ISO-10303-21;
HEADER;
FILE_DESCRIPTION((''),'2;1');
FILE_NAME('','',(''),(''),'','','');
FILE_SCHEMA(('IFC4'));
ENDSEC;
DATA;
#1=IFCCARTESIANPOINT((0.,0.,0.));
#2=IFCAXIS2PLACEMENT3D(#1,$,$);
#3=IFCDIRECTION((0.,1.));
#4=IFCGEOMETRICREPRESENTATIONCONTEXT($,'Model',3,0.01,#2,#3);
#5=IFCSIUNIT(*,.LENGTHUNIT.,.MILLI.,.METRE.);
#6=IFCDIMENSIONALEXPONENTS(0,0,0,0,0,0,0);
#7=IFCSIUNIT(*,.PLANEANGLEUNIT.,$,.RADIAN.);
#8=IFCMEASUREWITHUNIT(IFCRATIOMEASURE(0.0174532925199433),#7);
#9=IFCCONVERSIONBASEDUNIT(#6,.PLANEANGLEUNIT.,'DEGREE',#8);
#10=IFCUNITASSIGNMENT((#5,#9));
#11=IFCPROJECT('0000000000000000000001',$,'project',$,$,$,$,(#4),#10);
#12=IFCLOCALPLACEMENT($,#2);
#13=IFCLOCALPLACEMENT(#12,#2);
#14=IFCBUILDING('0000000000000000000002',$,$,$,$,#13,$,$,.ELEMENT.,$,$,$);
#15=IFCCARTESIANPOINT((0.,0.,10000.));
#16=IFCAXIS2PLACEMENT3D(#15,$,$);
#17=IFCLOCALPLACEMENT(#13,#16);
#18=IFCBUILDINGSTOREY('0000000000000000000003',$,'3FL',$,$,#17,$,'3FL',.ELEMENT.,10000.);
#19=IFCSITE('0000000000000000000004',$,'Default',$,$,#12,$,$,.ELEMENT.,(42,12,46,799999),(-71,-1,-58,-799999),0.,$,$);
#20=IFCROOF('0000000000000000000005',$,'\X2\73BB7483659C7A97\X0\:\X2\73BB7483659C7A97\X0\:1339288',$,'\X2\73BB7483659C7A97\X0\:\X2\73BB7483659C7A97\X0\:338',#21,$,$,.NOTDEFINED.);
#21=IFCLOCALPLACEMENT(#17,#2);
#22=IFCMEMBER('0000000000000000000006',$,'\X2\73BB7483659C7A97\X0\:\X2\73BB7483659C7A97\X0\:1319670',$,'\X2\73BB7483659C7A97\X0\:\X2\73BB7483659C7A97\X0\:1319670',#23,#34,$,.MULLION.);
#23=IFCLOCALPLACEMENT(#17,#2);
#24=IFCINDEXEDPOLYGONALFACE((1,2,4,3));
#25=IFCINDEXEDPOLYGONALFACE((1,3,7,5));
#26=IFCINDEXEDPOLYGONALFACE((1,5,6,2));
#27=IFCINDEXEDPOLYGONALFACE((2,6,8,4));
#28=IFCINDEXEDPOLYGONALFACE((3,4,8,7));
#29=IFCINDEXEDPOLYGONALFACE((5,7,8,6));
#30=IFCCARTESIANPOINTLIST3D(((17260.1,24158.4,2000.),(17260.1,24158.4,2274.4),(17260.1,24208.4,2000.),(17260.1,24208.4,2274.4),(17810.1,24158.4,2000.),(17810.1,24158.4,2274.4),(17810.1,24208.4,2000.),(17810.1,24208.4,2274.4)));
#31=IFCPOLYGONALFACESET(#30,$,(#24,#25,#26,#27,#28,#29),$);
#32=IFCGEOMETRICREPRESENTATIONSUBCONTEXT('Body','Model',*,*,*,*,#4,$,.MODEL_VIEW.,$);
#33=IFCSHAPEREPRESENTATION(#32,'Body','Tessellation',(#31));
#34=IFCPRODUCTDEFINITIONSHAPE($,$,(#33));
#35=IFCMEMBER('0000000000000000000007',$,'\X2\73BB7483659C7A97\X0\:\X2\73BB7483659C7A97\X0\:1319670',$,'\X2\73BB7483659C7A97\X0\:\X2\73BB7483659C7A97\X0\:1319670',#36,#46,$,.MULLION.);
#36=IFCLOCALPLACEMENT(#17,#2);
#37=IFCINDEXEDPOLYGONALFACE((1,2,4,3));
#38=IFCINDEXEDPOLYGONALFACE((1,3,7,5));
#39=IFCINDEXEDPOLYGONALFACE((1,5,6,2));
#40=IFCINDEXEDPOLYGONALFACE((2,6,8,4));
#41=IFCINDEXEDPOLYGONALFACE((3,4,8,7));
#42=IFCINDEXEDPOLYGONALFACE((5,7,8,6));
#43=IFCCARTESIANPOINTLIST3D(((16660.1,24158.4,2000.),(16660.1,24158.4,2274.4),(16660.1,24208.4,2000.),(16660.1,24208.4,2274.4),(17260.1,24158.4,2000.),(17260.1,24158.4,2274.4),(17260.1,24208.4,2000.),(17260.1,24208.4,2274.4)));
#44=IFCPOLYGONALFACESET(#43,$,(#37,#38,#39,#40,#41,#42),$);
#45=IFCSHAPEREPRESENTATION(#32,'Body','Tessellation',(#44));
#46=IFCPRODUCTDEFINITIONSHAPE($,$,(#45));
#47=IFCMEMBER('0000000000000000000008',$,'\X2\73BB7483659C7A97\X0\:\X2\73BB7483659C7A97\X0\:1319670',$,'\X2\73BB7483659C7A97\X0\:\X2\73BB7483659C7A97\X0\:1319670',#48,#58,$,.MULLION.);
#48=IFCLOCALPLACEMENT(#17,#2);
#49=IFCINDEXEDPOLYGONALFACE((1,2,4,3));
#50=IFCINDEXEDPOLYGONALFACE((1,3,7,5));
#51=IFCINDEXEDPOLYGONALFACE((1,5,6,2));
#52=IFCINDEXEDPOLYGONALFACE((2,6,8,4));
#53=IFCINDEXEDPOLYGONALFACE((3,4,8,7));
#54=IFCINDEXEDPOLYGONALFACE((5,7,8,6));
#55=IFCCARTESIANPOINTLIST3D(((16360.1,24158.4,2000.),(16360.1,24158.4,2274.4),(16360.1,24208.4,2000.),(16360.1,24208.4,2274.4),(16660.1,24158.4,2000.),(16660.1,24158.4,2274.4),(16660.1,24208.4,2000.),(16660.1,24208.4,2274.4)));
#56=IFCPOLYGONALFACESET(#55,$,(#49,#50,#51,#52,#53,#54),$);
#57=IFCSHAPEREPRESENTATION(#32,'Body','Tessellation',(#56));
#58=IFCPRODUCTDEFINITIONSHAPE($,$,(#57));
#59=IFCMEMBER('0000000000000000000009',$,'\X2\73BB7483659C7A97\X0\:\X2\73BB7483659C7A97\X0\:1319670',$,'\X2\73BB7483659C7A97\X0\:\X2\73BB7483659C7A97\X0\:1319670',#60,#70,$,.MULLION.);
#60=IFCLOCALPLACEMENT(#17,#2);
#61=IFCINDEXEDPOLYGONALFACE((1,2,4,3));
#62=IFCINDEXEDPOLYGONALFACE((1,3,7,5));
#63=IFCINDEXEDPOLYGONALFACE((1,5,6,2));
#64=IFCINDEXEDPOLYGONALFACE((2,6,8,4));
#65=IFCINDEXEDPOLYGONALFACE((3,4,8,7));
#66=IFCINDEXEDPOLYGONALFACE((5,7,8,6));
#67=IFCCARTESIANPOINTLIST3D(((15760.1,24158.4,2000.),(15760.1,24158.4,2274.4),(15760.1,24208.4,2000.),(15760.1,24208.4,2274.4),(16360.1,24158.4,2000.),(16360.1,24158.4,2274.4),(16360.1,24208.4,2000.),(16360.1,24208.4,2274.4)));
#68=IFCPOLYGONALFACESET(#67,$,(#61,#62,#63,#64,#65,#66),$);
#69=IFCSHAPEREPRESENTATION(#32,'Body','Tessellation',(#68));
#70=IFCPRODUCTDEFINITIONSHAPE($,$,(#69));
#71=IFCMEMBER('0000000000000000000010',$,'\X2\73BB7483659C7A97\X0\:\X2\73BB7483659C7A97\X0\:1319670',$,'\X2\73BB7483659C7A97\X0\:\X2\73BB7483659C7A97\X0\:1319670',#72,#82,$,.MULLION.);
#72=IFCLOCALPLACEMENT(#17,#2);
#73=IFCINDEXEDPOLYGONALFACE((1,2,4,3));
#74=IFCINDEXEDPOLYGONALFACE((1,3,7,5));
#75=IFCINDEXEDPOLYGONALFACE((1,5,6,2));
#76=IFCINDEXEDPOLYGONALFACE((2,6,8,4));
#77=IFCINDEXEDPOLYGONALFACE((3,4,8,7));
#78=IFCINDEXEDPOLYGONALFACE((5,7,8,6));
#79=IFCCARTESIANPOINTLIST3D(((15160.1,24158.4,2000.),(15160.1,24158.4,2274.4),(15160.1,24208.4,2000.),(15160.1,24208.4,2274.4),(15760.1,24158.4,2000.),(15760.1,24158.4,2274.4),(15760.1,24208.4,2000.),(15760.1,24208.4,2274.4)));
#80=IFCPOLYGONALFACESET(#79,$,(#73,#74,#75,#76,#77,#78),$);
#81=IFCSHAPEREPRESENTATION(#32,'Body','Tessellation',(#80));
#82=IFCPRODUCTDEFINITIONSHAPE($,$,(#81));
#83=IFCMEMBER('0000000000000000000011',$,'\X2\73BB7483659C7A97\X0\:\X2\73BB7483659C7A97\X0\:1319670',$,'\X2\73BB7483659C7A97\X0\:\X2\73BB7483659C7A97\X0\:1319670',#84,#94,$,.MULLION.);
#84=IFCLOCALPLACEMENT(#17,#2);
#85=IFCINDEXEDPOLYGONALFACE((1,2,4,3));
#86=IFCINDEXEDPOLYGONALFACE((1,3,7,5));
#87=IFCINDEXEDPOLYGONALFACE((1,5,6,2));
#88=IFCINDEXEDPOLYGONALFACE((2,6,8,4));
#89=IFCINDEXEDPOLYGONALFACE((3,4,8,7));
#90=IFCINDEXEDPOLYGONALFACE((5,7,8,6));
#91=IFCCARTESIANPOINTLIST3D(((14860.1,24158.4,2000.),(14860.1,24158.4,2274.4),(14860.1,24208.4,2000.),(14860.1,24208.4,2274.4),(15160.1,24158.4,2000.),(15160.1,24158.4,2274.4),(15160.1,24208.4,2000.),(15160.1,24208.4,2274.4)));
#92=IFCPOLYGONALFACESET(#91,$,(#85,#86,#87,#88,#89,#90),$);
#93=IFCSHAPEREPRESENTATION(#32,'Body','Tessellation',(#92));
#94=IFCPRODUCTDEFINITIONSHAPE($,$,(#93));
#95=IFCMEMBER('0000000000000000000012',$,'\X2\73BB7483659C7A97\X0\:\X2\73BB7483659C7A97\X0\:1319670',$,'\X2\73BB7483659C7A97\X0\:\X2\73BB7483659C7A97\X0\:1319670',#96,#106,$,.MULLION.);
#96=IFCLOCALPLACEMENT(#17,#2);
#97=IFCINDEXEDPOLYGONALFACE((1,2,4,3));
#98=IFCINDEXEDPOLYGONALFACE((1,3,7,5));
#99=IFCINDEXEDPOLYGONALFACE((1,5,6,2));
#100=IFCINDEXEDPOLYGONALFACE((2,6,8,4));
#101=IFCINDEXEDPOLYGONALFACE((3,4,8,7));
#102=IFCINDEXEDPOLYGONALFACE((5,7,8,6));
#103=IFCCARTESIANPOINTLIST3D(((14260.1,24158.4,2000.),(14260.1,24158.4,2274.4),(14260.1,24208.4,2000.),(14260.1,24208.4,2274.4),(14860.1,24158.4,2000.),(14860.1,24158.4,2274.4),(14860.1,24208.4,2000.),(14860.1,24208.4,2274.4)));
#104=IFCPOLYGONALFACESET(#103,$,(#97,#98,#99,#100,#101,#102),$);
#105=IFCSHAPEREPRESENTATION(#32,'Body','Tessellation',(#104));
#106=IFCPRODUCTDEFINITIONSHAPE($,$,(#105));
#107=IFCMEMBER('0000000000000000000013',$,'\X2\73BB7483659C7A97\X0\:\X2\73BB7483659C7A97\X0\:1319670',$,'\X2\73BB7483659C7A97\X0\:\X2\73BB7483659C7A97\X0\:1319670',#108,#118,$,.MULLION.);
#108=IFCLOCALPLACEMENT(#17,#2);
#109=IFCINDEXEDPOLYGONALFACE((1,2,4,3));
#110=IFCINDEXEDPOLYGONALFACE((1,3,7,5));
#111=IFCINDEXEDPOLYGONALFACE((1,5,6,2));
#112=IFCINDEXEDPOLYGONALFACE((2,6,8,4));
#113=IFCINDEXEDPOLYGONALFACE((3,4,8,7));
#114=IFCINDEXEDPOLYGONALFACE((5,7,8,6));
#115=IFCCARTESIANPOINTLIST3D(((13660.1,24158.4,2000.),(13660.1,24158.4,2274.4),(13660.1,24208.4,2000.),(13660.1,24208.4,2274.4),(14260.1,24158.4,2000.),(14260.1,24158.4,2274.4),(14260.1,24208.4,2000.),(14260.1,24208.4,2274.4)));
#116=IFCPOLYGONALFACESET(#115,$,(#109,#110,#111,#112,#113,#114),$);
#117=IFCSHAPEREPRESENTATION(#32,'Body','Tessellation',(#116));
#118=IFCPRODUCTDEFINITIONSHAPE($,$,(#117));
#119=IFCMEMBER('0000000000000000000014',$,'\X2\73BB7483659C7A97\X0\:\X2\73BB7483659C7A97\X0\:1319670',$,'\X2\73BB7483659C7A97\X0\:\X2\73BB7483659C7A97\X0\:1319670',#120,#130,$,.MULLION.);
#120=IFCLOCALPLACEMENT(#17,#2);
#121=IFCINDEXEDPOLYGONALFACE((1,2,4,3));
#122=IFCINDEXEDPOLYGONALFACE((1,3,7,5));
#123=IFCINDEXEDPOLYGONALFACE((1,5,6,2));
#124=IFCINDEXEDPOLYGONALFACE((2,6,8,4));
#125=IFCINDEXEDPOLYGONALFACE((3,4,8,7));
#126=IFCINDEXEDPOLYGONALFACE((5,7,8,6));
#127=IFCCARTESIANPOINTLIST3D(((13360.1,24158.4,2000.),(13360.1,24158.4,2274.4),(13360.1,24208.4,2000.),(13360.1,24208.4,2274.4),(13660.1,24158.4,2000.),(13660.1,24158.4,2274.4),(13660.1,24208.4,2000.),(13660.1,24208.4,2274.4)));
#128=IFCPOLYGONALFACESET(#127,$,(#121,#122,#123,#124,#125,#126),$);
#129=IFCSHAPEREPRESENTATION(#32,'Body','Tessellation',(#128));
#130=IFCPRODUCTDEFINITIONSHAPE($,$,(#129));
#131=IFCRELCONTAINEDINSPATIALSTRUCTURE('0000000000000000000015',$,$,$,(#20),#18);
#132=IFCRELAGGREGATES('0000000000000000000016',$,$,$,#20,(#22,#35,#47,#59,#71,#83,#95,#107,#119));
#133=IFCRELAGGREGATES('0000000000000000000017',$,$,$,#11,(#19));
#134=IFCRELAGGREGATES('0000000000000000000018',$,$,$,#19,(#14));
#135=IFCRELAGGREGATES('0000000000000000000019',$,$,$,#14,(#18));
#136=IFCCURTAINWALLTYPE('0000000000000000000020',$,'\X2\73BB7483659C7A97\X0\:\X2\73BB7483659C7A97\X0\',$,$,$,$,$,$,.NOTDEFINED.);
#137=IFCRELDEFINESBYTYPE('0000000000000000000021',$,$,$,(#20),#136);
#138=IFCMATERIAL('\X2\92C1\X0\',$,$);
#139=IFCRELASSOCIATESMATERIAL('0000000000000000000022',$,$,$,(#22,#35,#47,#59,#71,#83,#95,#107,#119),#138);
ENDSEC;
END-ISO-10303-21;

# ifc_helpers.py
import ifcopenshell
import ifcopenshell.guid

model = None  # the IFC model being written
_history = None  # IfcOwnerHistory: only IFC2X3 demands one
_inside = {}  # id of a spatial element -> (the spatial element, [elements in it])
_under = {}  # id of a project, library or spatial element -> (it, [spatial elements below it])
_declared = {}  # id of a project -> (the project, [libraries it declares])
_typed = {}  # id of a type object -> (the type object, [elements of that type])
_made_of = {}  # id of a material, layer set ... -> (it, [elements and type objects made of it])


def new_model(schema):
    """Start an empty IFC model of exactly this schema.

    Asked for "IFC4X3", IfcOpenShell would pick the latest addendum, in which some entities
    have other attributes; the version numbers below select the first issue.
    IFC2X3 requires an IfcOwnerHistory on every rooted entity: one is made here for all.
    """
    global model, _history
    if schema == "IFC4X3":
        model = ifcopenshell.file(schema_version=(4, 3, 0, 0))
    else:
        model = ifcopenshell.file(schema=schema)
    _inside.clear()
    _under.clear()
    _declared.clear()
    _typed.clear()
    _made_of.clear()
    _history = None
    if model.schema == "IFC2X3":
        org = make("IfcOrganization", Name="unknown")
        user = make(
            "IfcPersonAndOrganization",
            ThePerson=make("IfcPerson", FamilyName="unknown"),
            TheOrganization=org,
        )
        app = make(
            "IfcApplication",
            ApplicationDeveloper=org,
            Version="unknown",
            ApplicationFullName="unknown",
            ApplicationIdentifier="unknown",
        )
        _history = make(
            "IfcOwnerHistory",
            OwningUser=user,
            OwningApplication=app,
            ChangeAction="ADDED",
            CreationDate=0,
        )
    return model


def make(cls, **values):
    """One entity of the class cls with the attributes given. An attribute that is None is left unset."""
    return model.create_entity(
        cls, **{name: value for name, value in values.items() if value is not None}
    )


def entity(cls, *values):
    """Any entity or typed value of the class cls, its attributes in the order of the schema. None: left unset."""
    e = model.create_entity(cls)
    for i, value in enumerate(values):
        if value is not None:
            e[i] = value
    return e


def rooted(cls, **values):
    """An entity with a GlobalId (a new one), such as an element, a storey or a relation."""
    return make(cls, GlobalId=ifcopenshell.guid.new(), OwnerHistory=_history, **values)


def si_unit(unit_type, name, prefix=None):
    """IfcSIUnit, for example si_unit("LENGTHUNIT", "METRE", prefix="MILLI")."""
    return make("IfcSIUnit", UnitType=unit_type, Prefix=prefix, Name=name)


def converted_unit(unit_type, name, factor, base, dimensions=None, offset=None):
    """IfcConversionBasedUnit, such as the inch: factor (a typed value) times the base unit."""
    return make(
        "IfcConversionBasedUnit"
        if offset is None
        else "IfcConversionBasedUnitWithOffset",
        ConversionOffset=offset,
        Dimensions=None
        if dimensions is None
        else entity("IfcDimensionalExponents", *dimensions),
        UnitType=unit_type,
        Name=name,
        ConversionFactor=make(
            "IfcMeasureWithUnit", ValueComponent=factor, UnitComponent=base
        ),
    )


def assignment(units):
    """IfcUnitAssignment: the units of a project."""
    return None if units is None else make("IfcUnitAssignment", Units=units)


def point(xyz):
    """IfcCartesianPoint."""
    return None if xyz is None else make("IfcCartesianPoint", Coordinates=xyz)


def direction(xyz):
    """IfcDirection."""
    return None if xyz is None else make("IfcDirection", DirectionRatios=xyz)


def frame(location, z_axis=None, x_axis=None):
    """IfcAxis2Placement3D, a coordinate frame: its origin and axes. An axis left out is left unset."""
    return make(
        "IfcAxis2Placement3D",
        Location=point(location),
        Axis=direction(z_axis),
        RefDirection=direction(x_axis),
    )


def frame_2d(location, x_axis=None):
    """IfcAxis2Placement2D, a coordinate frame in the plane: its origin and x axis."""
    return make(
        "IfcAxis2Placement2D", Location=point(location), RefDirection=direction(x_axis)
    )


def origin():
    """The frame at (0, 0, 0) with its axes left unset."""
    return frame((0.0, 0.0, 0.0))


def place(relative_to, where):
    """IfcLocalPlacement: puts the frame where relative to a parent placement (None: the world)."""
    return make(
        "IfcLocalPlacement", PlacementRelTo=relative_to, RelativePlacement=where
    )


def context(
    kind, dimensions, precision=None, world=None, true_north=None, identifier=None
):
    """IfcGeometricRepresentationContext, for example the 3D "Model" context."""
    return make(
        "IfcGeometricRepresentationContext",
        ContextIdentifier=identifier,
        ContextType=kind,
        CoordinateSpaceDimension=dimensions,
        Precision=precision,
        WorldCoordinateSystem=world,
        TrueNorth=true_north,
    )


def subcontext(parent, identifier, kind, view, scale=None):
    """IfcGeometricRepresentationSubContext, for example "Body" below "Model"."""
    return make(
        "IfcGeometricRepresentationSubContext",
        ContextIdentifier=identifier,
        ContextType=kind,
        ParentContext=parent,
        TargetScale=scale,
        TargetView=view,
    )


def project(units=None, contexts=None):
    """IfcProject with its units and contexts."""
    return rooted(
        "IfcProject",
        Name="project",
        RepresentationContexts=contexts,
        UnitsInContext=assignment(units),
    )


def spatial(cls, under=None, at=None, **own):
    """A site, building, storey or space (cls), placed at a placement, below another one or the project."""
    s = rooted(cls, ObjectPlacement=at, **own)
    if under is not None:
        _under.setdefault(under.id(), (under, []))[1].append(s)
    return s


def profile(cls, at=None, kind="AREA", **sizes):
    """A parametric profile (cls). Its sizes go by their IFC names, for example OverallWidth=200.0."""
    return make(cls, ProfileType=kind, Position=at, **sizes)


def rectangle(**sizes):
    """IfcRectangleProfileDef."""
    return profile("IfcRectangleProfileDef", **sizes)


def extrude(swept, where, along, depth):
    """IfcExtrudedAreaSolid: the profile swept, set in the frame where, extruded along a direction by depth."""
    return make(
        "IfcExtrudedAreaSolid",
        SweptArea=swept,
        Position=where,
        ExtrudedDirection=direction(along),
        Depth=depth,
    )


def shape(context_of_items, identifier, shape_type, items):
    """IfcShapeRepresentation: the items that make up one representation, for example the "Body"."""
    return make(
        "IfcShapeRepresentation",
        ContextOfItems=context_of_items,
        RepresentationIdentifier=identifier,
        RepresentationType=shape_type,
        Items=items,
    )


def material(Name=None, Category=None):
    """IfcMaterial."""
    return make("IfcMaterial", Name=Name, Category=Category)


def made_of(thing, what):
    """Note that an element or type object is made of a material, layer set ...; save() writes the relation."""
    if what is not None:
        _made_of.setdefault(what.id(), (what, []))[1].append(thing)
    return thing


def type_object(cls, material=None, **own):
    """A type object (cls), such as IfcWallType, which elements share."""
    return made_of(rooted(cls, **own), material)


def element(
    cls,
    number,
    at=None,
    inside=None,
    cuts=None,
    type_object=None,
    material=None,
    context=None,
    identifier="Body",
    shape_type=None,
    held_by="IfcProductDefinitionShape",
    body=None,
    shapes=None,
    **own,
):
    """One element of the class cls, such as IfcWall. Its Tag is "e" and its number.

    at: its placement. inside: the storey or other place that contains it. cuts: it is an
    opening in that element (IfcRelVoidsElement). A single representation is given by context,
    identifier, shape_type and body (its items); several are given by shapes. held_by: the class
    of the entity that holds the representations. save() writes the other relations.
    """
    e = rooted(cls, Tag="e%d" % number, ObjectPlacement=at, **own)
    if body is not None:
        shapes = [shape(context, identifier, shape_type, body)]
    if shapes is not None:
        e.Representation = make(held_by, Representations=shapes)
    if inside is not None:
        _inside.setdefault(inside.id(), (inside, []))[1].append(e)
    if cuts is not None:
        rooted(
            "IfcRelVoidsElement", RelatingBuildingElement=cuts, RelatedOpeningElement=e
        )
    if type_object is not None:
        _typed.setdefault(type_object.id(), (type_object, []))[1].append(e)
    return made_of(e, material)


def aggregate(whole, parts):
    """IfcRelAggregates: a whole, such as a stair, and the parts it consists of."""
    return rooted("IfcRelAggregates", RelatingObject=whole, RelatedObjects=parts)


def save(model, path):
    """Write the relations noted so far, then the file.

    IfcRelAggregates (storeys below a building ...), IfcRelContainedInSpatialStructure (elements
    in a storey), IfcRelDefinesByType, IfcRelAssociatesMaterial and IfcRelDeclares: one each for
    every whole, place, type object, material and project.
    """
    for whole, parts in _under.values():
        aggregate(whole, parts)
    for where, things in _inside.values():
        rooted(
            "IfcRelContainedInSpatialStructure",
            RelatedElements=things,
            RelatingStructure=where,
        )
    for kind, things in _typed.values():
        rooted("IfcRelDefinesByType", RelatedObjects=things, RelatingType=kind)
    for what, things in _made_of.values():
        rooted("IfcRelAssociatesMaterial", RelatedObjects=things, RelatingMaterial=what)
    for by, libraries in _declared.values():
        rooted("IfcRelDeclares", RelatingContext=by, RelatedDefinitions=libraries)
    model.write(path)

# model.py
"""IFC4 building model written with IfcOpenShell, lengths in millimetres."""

from ifc_helpers import new_model, entity, si_unit, converted_unit, direction, frame, frame_2d, origin, place, context, subcontext, project, spatial, rectangle, extrude, material, type_object, element, aggregate, save


model = new_model("IFC4")

# Units and contexts
model_context = context("Model", 3, precision=0.01, world=origin(), true_north=direction((0.0, 1.0)))
body_context = subcontext(model_context, "Body", "Model", "MODEL_VIEW")
ifc_project = project(units=[si_unit("LENGTHUNIT", "METRE", prefix="MILLI"), converted_unit("PLANEANGLEUNIT", "DEGREE", entity("IfcRatioMeasure", 0.0174532925199433), si_unit("PLANEANGLEUNIT", "RADIAN"), dimensions=[0, 0, 0, 0, 0, 0, 0])], contexts=[model_context])

# Site, building, storey
site_placement = place(None, origin())
site = spatial("IfcSite", under=ifc_project, at=site_placement, Name="Default", CompositionType="ELEMENT", RefLatitude=(42, 12, 46, 799999), RefLongitude=(-71, -1, -58, -799999), RefElevation=0.0)
building_placement = place(site_placement, origin())
building = spatial("IfcBuilding", under=site, at=building_placement, CompositionType="ELEMENT")
storey_placement = place(building_placement, frame((0.0, 0.0, 10000.0)))
storey = spatial("IfcBuildingStorey", under=building, at=storey_placement, Name="3FL", LongName="3FL", CompositionType="ELEMENT", Elevation=10000.0)

# Roof, members
curtain_wall_type = type_object("IfcCurtainWallType", Name="玻璃斜窗:玻璃斜窗", PredefinedType="NOTDEFINED")
ifc_material = material(Name="鋁")
roof_1_placement = place(storey_placement, frame((0.0, 0.0, -10000.0)))
roof_1 = element("IfcRoof", 1, at=roof_1_placement, inside=storey, type_object=curtain_wall_type, Name="玻璃斜窗:玻璃斜窗:1339288", ObjectType="玻璃斜窗:玻璃斜窗:338", PredefinedType="NOTDEFINED")
member_1_placement = place(roof_1_placement, frame((0.0, 0.0, 10000.0)))
member_1 = element("IfcMember", 2, at=member_1_placement, material=ifc_material, Name="玻璃斜窗:玻璃斜窗:1319670", ObjectType="玻璃斜窗:玻璃斜窗:1319670", PredefinedType="MULLION", context=body_context, shape_type="SweptSolid", body=[
    extrude(rectangle(XDim=274.5, YDim=50.0, at=frame_2d((0.0, 0.0), x_axis=(1.0, 0.0))), frame((17260.1, 24183.4, 2137.2), z_axis=(1.0, 0.0, 0.0), x_axis=(0.0, 0.0, -1.0)), (0.0, 0.0, 1.0), 550.0),
])
member_2_placement = place(roof_1_placement, frame((0.0, 0.0, 10000.0)))
member_2 = element("IfcMember", 3, at=member_2_placement, material=ifc_material, Name="玻璃斜窗:玻璃斜窗:1319670", ObjectType="玻璃斜窗:玻璃斜窗:1319670", PredefinedType="MULLION", context=body_context, shape_type="SweptSolid", body=[
    extrude(rectangle(XDim=274.5, YDim=50.0, at=frame_2d((0.0, 0.0), x_axis=(1.0, 0.0))), frame((16660.1, 24183.4, 2137.2), z_axis=(1.0, 0.0, 0.0), x_axis=(0.0, 0.0, -1.0)), (0.0, 0.0, 1.0), 600.0),
])
member_3_placement = place(roof_1_placement, frame((0.0, 0.0, 10000.0)))
member_3 = element("IfcMember", 4, at=member_3_placement, material=ifc_material, Name="玻璃斜窗:玻璃斜窗:1319670", ObjectType="玻璃斜窗:玻璃斜窗:1319670", PredefinedType="MULLION", context=body_context, shape_type="SweptSolid", body=[
    extrude(rectangle(XDim=274.5, YDim=50.0, at=frame_2d((0.0, 0.0), x_axis=(1.0, 0.0))), frame((16360.1, 24183.4, 2137.2), z_axis=(1.0, 0.0, 0.0), x_axis=(0.0, 0.0, -1.0)), (0.0, 0.0, 1.0), 300.0),
])
member_4_placement = place(roof_1_placement, frame((0.0, 0.0, 10000.0)))
member_4 = element("IfcMember", 5, at=member_4_placement, material=ifc_material, Name="玻璃斜窗:玻璃斜窗:1319670", ObjectType="玻璃斜窗:玻璃斜窗:1319670", PredefinedType="MULLION", context=body_context, shape_type="SweptSolid", body=[
    extrude(rectangle(XDim=274.5, YDim=50.0, at=frame_2d((0.0, 0.0), x_axis=(1.0, 0.0))), frame((15760.1, 24183.4, 2137.2), z_axis=(1.0, 0.0, 0.0), x_axis=(0.0, 0.0, -1.0)), (0.0, 0.0, 1.0), 600.0),
])
member_5_placement = place(roof_1_placement, frame((0.0, 0.0, 10000.0)))
member_5 = element("IfcMember", 6, at=member_5_placement, material=ifc_material, Name="玻璃斜窗:玻璃斜窗:1319670", ObjectType="玻璃斜窗:玻璃斜窗:1319670", PredefinedType="MULLION", context=body_context, shape_type="SweptSolid", body=[
    extrude(rectangle(XDim=274.5, YDim=50.0, at=frame_2d((0.0, 0.0), x_axis=(1.0, 0.0))), frame((15160.1, 24183.4, 2137.2), z_axis=(1.0, 0.0, 0.0), x_axis=(0.0, 0.0, -1.0)), (0.0, 0.0, 1.0), 600.0),
])
member_6_placement = place(roof_1_placement, frame((0.0, 0.0, 10000.0)))
member_6 = element("IfcMember", 7, at=member_6_placement, material=ifc_material, Name="玻璃斜窗:玻璃斜窗:1319670", ObjectType="玻璃斜窗:玻璃斜窗:1319670", PredefinedType="MULLION", context=body_context, shape_type="SweptSolid", body=[
    extrude(rectangle(XDim=274.5, YDim=50.0, at=frame_2d((0.0, 0.0), x_axis=(1.0, 0.0))), frame((14860.1, 24183.4, 2137.2), z_axis=(1.0, 0.0, 0.0), x_axis=(0.0, 0.0, -1.0)), (0.0, 0.0, 1.0), 300.0),
])
member_7_placement = place(roof_1_placement, frame((0.0, 0.0, 10000.0)))
member_7 = element("IfcMember", 8, at=member_7_placement, material=ifc_material, Name="玻璃斜窗:玻璃斜窗:1319670", ObjectType="玻璃斜窗:玻璃斜窗:1319670", PredefinedType="MULLION", context=body_context, shape_type="SweptSolid", body=[
    extrude(rectangle(XDim=274.5, YDim=50.0, at=frame_2d((0.0, 0.0), x_axis=(1.0, 0.0))), frame((14260.1, 24183.4, 2137.2), z_axis=(1.0, 0.0, 0.0), x_axis=(0.0, 0.0, -1.0)), (0.0, 0.0, 1.0), 600.0),
])
member_8_placement = place(roof_1_placement, frame((0.0, 0.0, 10000.0)))
member_8 = element("IfcMember", 9, at=member_8_placement, material=ifc_material, Name="玻璃斜窗:玻璃斜窗:1319670", ObjectType="玻璃斜窗:玻璃斜窗:1319670", PredefinedType="MULLION", context=body_context, shape_type="SweptSolid", body=[
    extrude(rectangle(XDim=274.5, YDim=50.0, at=frame_2d((0.0, 0.0), x_axis=(1.0, 0.0))), frame((13660.1, 24183.4, 2137.2), z_axis=(1.0, 0.0, 0.0), x_axis=(0.0, 0.0, -1.0)), (0.0, 0.0, 1.0), 600.0),
])
member_9_placement = place(roof_1_placement, frame((0.0, 0.0, 10000.0)))
member_9 = element("IfcMember", 10, at=member_9_placement, material=ifc_material, Name="玻璃斜窗:玻璃斜窗:1319670", ObjectType="玻璃斜窗:玻璃斜窗:1319670", PredefinedType="MULLION", context=body_context, shape_type="SweptSolid", body=[
    extrude(rectangle(XDim=274.5, YDim=50.0, at=frame_2d((0.0, 0.0), x_axis=(1.0, 0.0))), frame((13360.1, 24183.4, 2137.2), z_axis=(1.0, 0.0, 0.0), x_axis=(0.0, 0.0, -1.0)), (0.0, 0.0, 1.0), 300.0),
])
aggregate(roof_1, [member_1, member_2, member_3, member_4, member_5, member_6, member_7, member_8, member_9])

save(model, "model.ifc")
